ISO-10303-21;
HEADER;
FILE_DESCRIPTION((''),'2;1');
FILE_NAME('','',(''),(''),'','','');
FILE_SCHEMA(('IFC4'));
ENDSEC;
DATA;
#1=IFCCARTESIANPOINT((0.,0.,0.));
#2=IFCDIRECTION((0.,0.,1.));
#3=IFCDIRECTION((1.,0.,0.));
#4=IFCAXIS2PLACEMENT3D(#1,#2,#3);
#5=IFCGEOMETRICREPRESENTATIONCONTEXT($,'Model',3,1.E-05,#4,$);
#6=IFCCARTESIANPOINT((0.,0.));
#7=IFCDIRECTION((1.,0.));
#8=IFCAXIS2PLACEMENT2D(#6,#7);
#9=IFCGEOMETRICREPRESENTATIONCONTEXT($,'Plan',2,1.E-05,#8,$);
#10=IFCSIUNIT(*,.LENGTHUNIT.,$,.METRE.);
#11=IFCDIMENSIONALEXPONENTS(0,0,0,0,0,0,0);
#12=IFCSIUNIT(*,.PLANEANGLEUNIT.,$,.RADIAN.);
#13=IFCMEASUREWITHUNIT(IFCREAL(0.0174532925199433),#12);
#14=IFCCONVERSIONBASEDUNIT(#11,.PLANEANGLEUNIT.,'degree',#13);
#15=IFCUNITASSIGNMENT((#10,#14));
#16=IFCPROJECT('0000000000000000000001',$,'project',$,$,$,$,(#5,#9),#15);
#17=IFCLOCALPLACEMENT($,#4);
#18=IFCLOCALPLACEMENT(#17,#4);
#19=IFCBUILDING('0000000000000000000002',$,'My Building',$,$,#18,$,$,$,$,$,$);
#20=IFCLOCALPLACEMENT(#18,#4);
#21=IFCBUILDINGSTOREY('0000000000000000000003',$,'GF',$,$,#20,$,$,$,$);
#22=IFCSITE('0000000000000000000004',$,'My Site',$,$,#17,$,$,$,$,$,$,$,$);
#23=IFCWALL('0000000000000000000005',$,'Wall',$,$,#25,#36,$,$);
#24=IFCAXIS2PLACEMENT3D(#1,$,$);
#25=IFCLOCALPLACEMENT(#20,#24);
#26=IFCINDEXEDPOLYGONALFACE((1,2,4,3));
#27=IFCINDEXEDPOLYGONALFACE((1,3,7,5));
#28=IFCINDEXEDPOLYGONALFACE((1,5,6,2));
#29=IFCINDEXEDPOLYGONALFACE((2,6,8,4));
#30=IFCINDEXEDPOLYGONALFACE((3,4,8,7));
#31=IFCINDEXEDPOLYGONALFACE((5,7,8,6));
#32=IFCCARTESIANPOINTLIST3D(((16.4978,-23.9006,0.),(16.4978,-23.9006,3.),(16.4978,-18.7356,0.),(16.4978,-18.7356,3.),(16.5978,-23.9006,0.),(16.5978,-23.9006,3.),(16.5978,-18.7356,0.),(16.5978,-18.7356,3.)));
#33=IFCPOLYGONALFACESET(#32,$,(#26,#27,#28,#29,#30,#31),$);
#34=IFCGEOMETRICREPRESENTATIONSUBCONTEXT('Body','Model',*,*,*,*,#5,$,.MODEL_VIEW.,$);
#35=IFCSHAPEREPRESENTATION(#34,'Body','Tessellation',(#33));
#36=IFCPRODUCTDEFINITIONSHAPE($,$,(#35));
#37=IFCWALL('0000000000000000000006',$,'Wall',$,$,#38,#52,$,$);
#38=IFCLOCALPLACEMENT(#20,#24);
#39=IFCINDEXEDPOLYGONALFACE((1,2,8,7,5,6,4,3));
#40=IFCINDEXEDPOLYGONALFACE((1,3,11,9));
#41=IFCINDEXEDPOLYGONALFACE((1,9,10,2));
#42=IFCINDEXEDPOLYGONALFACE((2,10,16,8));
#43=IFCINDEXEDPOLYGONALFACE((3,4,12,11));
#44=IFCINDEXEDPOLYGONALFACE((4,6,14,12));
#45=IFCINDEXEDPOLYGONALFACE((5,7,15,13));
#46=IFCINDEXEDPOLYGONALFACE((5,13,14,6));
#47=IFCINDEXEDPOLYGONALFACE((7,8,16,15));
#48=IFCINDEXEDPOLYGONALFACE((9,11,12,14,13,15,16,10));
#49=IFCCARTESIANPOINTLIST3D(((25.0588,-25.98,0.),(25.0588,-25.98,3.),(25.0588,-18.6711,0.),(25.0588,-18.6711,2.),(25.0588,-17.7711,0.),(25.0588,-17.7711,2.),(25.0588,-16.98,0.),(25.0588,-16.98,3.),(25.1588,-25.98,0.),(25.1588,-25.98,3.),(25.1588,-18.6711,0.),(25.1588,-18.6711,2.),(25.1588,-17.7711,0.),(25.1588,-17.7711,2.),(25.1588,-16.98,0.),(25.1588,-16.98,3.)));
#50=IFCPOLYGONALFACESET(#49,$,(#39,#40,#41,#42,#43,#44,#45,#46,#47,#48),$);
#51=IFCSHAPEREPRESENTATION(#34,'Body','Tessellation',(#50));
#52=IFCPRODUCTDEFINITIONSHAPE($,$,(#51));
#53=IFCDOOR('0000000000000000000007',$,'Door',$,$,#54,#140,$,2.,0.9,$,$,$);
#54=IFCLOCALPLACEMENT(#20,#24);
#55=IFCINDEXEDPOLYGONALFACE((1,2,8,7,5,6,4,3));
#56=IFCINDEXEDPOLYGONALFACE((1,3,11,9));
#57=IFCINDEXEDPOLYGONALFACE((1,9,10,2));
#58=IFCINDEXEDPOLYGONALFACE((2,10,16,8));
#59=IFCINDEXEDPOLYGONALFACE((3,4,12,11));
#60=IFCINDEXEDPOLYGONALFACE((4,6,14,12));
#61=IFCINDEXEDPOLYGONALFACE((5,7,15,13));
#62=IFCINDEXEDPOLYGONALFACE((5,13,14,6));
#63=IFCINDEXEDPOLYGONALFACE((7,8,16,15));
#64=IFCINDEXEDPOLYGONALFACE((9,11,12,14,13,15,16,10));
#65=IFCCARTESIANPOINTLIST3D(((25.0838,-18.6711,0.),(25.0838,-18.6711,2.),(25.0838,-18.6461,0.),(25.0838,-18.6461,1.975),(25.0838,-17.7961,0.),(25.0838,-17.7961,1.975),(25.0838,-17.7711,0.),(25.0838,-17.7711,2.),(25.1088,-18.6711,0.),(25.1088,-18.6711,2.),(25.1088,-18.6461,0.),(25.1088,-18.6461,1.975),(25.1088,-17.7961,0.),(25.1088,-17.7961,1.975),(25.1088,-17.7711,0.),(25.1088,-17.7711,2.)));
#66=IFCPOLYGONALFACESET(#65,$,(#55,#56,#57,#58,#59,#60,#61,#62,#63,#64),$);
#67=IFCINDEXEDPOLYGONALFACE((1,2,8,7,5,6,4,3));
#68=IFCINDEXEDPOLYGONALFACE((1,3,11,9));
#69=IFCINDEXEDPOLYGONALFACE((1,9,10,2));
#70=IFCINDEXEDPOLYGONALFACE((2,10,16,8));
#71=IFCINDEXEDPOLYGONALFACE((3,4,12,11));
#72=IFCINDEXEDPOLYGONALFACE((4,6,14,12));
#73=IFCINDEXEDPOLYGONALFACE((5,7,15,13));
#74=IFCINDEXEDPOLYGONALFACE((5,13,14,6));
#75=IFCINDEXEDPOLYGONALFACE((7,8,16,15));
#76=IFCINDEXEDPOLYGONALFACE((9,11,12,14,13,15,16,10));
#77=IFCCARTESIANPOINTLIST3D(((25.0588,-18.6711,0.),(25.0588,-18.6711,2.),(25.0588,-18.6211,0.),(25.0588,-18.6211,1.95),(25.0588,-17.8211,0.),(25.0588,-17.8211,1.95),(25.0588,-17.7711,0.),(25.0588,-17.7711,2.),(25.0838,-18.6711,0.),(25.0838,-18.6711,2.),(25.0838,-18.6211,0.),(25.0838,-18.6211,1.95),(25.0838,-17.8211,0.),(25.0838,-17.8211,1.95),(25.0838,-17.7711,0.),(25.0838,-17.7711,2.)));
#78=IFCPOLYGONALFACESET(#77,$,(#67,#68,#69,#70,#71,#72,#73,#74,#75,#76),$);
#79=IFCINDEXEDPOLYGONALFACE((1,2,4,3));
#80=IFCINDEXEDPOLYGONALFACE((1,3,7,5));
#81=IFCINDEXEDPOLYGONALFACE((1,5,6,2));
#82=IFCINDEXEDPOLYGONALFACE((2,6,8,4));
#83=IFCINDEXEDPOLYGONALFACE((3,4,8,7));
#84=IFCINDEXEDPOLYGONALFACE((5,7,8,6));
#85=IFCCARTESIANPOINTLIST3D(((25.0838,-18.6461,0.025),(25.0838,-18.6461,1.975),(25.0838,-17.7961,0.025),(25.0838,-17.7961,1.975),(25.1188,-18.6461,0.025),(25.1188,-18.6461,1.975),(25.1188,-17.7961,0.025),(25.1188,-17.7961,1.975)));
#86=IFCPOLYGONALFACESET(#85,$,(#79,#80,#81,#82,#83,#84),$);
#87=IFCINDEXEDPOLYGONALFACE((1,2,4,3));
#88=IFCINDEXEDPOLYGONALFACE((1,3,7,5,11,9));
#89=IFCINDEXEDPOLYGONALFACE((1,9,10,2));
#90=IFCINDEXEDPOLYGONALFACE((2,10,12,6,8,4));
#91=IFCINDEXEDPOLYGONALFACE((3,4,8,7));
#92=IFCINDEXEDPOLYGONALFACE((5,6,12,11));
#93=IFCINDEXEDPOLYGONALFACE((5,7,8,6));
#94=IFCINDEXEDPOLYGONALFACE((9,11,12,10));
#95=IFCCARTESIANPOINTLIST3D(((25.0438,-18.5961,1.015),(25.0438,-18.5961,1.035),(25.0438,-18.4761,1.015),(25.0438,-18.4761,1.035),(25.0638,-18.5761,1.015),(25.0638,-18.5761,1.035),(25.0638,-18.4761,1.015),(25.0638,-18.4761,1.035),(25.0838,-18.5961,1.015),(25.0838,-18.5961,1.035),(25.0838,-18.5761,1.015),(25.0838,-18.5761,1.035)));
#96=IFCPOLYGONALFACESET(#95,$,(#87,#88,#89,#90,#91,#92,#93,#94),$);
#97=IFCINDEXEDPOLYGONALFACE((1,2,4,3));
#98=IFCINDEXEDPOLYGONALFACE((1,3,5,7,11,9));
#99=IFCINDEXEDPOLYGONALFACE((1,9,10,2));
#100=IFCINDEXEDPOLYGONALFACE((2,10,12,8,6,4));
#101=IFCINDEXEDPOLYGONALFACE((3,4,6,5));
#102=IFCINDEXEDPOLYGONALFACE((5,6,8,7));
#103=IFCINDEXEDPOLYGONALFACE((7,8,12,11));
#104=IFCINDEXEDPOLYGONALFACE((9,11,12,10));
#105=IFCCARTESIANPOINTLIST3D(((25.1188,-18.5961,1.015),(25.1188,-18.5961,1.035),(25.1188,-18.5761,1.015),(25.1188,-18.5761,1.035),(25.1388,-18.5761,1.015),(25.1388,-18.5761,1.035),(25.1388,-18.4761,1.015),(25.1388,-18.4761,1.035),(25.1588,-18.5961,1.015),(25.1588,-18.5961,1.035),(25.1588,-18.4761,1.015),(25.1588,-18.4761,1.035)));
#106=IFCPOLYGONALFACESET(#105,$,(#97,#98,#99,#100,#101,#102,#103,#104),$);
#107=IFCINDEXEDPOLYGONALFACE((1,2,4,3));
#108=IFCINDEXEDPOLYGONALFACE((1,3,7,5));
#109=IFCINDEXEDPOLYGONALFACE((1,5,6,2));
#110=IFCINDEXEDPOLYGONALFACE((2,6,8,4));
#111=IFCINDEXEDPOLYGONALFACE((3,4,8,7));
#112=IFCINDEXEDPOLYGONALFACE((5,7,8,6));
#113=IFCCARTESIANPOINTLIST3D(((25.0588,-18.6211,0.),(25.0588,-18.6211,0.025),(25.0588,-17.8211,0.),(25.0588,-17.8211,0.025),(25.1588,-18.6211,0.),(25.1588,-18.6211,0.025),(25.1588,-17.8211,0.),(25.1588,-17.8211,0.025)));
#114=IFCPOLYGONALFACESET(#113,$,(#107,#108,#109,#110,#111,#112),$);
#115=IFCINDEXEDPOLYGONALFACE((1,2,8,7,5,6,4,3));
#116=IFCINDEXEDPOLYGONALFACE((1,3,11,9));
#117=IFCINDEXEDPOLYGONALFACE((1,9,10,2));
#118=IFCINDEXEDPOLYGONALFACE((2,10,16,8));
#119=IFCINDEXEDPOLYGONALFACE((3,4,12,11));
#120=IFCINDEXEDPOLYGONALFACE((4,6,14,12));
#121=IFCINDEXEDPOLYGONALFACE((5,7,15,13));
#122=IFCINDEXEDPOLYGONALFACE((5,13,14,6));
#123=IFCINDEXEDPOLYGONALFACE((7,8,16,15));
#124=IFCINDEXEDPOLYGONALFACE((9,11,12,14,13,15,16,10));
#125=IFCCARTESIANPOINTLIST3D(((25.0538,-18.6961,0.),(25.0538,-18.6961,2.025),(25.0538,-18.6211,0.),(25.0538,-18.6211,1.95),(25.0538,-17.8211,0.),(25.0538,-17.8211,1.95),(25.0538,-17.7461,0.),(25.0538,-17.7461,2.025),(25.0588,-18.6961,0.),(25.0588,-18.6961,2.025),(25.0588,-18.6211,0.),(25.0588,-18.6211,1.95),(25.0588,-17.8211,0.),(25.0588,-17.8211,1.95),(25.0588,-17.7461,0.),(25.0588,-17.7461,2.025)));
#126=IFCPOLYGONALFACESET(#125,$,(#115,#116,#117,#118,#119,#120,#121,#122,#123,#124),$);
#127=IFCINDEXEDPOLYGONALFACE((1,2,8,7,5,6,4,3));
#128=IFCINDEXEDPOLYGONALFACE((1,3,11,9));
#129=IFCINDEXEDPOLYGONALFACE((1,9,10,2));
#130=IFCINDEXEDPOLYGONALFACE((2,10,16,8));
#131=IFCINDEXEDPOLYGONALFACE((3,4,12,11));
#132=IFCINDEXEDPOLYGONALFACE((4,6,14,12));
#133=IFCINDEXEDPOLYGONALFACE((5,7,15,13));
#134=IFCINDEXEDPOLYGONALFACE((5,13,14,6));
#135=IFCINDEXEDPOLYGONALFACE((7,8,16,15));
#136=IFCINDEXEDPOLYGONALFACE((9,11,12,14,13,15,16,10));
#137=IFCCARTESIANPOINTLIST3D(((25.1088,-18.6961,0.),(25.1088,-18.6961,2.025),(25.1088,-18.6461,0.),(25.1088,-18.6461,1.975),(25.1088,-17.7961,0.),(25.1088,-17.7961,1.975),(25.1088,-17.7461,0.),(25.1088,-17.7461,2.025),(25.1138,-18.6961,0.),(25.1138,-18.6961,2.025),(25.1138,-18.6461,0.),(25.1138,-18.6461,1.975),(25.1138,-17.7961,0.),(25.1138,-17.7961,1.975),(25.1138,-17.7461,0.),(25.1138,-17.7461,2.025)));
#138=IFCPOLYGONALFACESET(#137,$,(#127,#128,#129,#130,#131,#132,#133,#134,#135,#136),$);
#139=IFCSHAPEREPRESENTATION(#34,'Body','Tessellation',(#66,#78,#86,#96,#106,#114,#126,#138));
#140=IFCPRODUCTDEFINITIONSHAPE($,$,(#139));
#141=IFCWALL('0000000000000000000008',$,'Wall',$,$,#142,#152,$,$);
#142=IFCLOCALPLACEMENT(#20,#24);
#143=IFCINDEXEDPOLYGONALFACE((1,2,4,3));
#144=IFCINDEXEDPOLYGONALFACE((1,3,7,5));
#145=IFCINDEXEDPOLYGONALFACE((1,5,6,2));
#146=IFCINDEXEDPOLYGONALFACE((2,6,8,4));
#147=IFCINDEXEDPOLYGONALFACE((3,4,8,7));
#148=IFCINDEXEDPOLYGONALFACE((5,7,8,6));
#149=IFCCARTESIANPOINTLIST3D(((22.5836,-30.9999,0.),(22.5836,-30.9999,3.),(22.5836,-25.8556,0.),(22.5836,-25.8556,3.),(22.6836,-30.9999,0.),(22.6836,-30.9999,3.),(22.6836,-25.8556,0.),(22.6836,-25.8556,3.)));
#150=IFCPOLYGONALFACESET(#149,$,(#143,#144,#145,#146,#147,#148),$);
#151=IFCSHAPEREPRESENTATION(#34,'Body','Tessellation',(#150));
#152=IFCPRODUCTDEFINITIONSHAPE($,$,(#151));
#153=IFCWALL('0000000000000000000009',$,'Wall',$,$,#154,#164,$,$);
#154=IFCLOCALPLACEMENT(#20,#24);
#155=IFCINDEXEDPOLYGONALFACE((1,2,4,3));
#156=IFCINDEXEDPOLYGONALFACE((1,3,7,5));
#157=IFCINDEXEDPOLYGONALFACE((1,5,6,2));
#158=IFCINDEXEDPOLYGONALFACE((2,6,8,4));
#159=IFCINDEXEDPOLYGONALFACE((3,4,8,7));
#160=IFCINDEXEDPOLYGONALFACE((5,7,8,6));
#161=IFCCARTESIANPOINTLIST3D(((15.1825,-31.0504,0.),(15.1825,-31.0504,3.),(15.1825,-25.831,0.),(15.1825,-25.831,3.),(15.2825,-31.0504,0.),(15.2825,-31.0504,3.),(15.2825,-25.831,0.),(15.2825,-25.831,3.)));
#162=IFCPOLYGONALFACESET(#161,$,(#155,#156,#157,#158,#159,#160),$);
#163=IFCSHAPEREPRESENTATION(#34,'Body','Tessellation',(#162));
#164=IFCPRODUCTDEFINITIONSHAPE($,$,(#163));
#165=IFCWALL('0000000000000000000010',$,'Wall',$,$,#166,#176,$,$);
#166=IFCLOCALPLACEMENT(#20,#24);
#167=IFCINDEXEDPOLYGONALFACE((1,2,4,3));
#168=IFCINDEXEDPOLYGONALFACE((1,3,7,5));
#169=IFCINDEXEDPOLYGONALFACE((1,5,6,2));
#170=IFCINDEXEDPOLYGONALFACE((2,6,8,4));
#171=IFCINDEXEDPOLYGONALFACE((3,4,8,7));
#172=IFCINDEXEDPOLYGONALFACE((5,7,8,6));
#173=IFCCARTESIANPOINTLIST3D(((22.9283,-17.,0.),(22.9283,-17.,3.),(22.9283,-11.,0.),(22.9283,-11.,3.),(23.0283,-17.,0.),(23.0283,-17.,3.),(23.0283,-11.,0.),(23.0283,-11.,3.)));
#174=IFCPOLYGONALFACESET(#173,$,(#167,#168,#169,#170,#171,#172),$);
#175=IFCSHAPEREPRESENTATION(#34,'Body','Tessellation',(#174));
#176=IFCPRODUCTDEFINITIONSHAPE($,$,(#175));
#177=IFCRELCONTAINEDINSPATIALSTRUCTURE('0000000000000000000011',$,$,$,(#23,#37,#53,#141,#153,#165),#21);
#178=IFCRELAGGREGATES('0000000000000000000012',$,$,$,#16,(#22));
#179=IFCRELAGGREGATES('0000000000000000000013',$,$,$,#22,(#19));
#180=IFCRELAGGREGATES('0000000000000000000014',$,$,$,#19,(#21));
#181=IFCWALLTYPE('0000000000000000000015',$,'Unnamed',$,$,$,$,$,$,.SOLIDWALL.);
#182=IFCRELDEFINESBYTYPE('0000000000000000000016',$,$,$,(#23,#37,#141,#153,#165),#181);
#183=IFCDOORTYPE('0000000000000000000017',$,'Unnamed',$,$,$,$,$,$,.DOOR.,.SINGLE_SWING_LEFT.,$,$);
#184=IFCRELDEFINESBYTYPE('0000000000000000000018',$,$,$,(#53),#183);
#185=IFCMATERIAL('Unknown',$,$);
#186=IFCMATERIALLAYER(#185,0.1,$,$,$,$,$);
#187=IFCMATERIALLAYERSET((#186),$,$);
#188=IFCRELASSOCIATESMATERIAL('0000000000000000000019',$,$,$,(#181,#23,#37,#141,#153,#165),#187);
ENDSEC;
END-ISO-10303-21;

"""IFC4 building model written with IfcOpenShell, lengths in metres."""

from ifc_helpers import new_model, entity, si_unit, converted_unit, frame, origin_with_axes, origin_2d_with_axis, place, context, subcontext, project, spatial, line, indexed_curve, outline, extrude, shape, source, transform, mapped, material, layer, layer_set, layer_usage, type_object, type_shapes, element, fill, save


model = new_model("IFC4")

# Units and contexts
model_context = context("Model", 3, precision=1e-05, world=origin_with_axes())
plan_context = context("Plan", 2, precision=1e-05, world=origin_2d_with_axis())
body_context_1 = subcontext(model_context, "Body", "Model", "MODEL_VIEW")
body_context_2 = subcontext(plan_context, "Body", "Plan", "PLAN_VIEW")
ifc_project = project(units=[si_unit("LENGTHUNIT", "METRE"), converted_unit("PLANEANGLEUNIT", "degree", entity("IfcReal", 0.0174532925199433), si_unit("PLANEANGLEUNIT", "RADIAN"), dimensions=[0, 0, 0, 0, 0, 0, 0])], contexts=[model_context, plan_context])

# Site, building, storey
site_placement = place(None, origin_with_axes())
site = spatial("IfcSite", under=ifc_project, at=site_placement, Name="My Site")
building_placement = place(site_placement, origin_with_axes())
building = spatial("IfcBuilding", under=site, at=building_placement, Name="My Building")
storey_placement = place(building_placement, origin_with_axes())
storey = spatial("IfcBuildingStorey", under=building, at=storey_placement, Name="GF")

# Shared definitions
ifc_material = material(Name="Unknown")
ifc_layer = layer(ifc_material, 0.1)
ifc_layer_set = layer_set([ifc_layer])
wall_type = type_object("IfcWallType", Name="Unnamed", PredefinedType="SOLIDWALL", material=ifc_layer_set)

# Shared definitions
shared_shape_1 = source(origin_with_axes(), body_context_1, "Body", "SweptSolid", [
    extrude(outline(indexed_curve([(0.0, 0.0), (0.9, 0.0), (0.9, 2.0), (0.0, 2.0)], segments=[line(1, 2, 3, 4, 1)])), frame((0.0, -0.6, 0.0), z_axis=(0.0, -1.0, 0.0), x_axis=(1.0, 0.0, 0.0)), (0.0, 0.0, -1.0), 1.2),
])
door_type = type_object("IfcDoorType", Name="Unnamed", OperationType="SINGLE_SWING_LEFT", PredefinedType="DOOR")
shared_shape_2 = source(origin_with_axes(), body_context_1, "Body", "SweptSolid", [
    extrude(outline(indexed_curve([(0.0, 0.0), (0.0, 2.0), (0.9, 2.0), (0.9, 0.0), (0.875, 0.0), (0.875, 1.975), (0.025, 1.975), (0.025, 0.0)], segments=[line(1, 2, 3, 4, 5, 6, 7, 8, 1)])), frame((0.0, 0.025, 0.0), z_axis=(0.0, -1.0, 0.0), x_axis=(1.0, 0.0, 0.0)), (0.0, 0.0, -1.0), 0.025),
    extrude(outline(indexed_curve([(0.0, 0.0), (0.0, 2.0), (0.9, 2.0), (0.9, 0.0), (0.85, 0.0), (0.85, 1.95), (0.05, 1.95), (0.05, 0.0)], segments=[line(1, 2, 3, 4, 5, 6, 7, 8, 1)])), frame((0.0, 0.0, 0.0), z_axis=(0.0, -1.0, 0.0), x_axis=(1.0, 0.0, 0.0)), (0.0, 0.0, -1.0), 0.025),
    extrude(outline(indexed_curve([(0.0, 0.0), (0.85, 0.0), (0.85, 0.035), (0.0, 0.035)], segments=[line(1, 2, 3, 4, 1)])), frame((0.025, 0.025, 0.025), z_axis=(0.0, 0.0, 1.0), x_axis=(1.0, 0.0, 0.0)), (0.0, 0.0, 1.0), 1.95),
    extrude(outline(indexed_curve([(0.0, 0.0), (0.0, -0.04), (-0.12, -0.04), (-0.12, -0.02), (-0.02, -0.02), (-0.02, 0.0)], segments=[line(1, 2, 3, 4, 5, 6, 1)])), frame((0.825, 0.025, 1.015), z_axis=(0.0, 0.0, 1.0), x_axis=(1.0, 0.0, 0.0)), (0.0, 0.0, 1.0), 0.02),
    extrude(outline(indexed_curve([(0.0, 0.0), (0.0, 0.04), (-0.12, 0.04), (-0.12, 0.02), (-0.02, 0.02), (-0.02, 0.0)], segments=[line(1, 2, 3, 4, 5, 6, 1)])), frame((0.825, 0.06, 1.015), z_axis=(0.0, 0.0, 1.0), x_axis=(1.0, 0.0, 0.0)), (0.0, 0.0, 1.0), 0.02),
    extrude(outline(indexed_curve([(0.0, 0.0), (0.8, 0.0), (0.8, 0.1), (0.0, 0.1)], segments=[line(1, 2, 3, 4, 1)])), frame((0.05, 0.0, 0.0), z_axis=(0.0, 0.0, 1.0), x_axis=(1.0, 0.0, 0.0)), (0.0, 0.0, 1.0), 0.025),
    extrude(outline(indexed_curve([(0.0, 0.0), (0.0, 2.025), (0.95, 2.025), (0.95, 0.0), (0.875, 0.0), (0.875, 1.95), (0.075, 1.95), (0.075, 0.0)], segments=[line(1, 2, 3, 4, 5, 6, 7, 8, 1)])), frame((-0.025, -0.005, 0.0), z_axis=(0.0, -1.0, 0.0), x_axis=(1.0, 0.0, 0.0)), (0.0, 0.0, -1.0), 0.005),
    extrude(outline(indexed_curve([(0.0, 0.0), (0.0, 2.025), (0.95, 2.025), (0.95, 0.0), (0.9, 0.0), (0.9, 1.975), (0.05, 1.975), (0.05, 0.0)], segments=[line(1, 2, 3, 4, 5, 6, 7, 8, 1)])), frame((-0.025, 0.05, 0.0), z_axis=(0.0, -1.0, 0.0), x_axis=(1.0, 0.0, 0.0)), (0.0, 0.0, -1.0), 0.005),
])
shared_shape_3 = source(origin_with_axes(), body_context_2, "Body", "Curve2D", [
    entity("IfcIndexedPolyCurve", entity("IfcCartesianPointList2D", [[0.0, 0.0], [0.0, 0.05], [0.025, 0.05], [0.025, 0.025], [0.05, 0.025], [0.05, 0.0]]), [entity("IfcLineIndex", [1, 2, 3, 4, 5, 6, 1])]),
    entity("IfcIndexedPolyCurve", entity("IfcCartesianPointList2D", [[0.9, 0.0], [0.9, 0.05], [0.875, 0.05], [0.875, 0.025], [0.85, 0.025], [0.85, 0.0]]), [entity("IfcLineIndex", [1, 2, 3, 4, 5, 6, 1])]),
    entity("IfcTrimmedCurve", entity("IfcEllipse", entity("IfcAxis2Placement2D", entity("IfcCartesianPoint", [0.06, 0.05]), entity("IfcDirection", [1.0, 0.0])), 0.815, 0.85), [entity("IfcCartesianPoint", [0.875, 0.05])], [entity("IfcCartesianPoint", [0.06, 0.9])], True, "CARTESIAN"),
    entity("IfcIndexedPolyCurve", entity("IfcCartesianPointList2D", [[0.025, 0.05], [0.06, 0.05], [0.06, 0.9], [0.025, 0.9]]), [entity("IfcLineIndex", [1, 2, 3, 4, 1])]),
])
type_shapes(door_type, [shared_shape_2, shared_shape_3])

# Wall
ifc_layer_usage_1 = layer_usage(ifc_layer_set, "AXIS2", "POSITIVE", 0.0)
wall_1_placement = place(storey_placement, frame((16.4978, -18.7356, 0.0), z_axis=(0.0, 0.0, 1.0), x_axis=(0.0, -1.0, 0.0)))
element("IfcWall", 1, at=wall_1_placement, inside=storey, type_object=wall_type, material=ifc_layer_usage_1, Name="Wall", context=body_context_1, shape_type="SweptSolid", body=[
    extrude(outline(indexed_curve([(0.0, 0.0), (0.0, 0.1), (5.1651, 0.1), (5.1651, 0.0)], segments=[line(1, 2, 3, 4, 1)])), origin_with_axes(), (0.0, 0.0, 1.0), 3.0),
])

# Wall, opening, door
ifc_layer_usage_2 = layer_usage(ifc_layer_set, "AXIS2", "POSITIVE", 0.0)
wall_2_placement = place(storey_placement, frame((25.0588, -16.98, 0.0), z_axis=(0.0, 0.0, 1.0), x_axis=(0.0, -1.0, 0.0)))
wall_2 = element("IfcWall", 2, at=wall_2_placement, inside=storey, type_object=wall_type, material=ifc_layer_usage_2, Name="Wall", context=body_context_1, shape_type="SweptSolid", body=[
    extrude(outline(indexed_curve([(0.0, 0.0), (0.0, 0.1), (9.0, 0.1), (9.0, 0.0)], segments=[line(1, 2, 3, 4, 1)])), origin_with_axes(), (0.0, 0.0, 1.0), 3.0),
])
opening_1_placement = place(wall_2_placement, frame((0.7911, 0.0, 0.0), z_axis=(0.0, 0.0, 1.0), x_axis=(1.0, 0.0, 0.0)))
opening_1 = element("IfcOpeningElement", 3, at=opening_1_placement, cuts=wall_2, PredefinedType="OPENING", context=body_context_1, shape_type="MappedRepresentation", body=[
    mapped(shared_shape_1, transform((0.0, 0.0, 0.0), x_axis=(1.0, 0.0, 0.0), y_axis=(0.0, 1.0, 0.0), z_axis=(0.0, 0.0, 1.0), scale=1.0)),
])
door_1_placement = place(opening_1_placement, frame((0.0, 0.0, 0.0), z_axis=(0.0, 0.0, 1.0), x_axis=(1.0, 0.0, 0.0)))
door_1 = element("IfcDoor", 4, at=door_1_placement, inside=storey, type_object=door_type, Name="Door", OverallHeight=2.0, OverallWidth=0.9, shapes=[
    shape(body_context_1, "Body", "MappedRepresentation", [mapped(shared_shape_2, transform((0.0, 0.0, 0.0), x_axis=(1.0, 0.0, 0.0), y_axis=(0.0, 1.0, 0.0), z_axis=(0.0, 0.0, 1.0), scale=1.0))]),
    shape(body_context_2, "Body", "MappedRepresentation", [mapped(shared_shape_3, transform((0.0, 0.0, 0.0), x_axis=(1.0, 0.0, 0.0), y_axis=(0.0, 1.0, 0.0), z_axis=(0.0, 0.0, 1.0), scale=1.0))]),
])
fill(opening_1, door_1)

# Walls
ifc_layer_usage_3 = layer_usage(ifc_layer_set, "AXIS2", "POSITIVE", 0.0)
wall_3_placement = place(storey_placement, frame((22.5836, -25.8556, 0.0), z_axis=(0.0, 0.0, 1.0), x_axis=(0.0, -1.0, 0.0)))
element("IfcWall", 5, at=wall_3_placement, inside=storey, type_object=wall_type, material=ifc_layer_usage_3, Name="Wall", context=body_context_1, shape_type="SweptSolid", body=[
    extrude(outline(indexed_curve([(0.0, 0.0), (0.0, 0.1), (5.1443, 0.1), (5.1443, 0.0)], segments=[line(1, 2, 3, 4, 1)])), origin_with_axes(), (0.0, 0.0, 1.0), 3.0),
])
ifc_layer_usage_4 = layer_usage(ifc_layer_set, "AXIS2", "POSITIVE", 0.0)
wall_4_placement = place(storey_placement, frame((15.1825, -25.831, 0.0), z_axis=(0.0, 0.0, 1.0), x_axis=(0.0, -1.0, 0.0)))
element("IfcWall", 6, at=wall_4_placement, inside=storey, type_object=wall_type, material=ifc_layer_usage_4, Name="Wall", context=body_context_1, shape_type="SweptSolid", body=[
    extrude(outline(indexed_curve([(0.0, 0.0), (0.0, 0.1), (5.2194, 0.1), (5.2194, 0.0)], segments=[line(1, 2, 3, 4, 1)])), origin_with_axes(), (0.0, 0.0, 1.0), 3.0),
])
ifc_layer_usage_5 = layer_usage(ifc_layer_set, "AXIS2", "POSITIVE", 0.0)
wall_5_placement = place(storey_placement, frame((22.9283, -11.0, 0.0), z_axis=(0.0, 0.0, 1.0), x_axis=(0.0, -1.0, 0.0)))
element("IfcWall", 7, at=wall_5_placement, inside=storey, type_object=wall_type, material=ifc_layer_usage_5, Name="Wall", context=body_context_1, shape_type="SweptSolid", body=[
    extrude(outline(indexed_curve([(0.0, 0.0), (0.0, 0.1), (6.0, 0.1), (6.0, 0.0)], segments=[line(1, 2, 3, 4, 1)])), origin_with_axes(), (0.0, 0.0, 1.0), 3.0),
])

save(model, "model.ifc")
